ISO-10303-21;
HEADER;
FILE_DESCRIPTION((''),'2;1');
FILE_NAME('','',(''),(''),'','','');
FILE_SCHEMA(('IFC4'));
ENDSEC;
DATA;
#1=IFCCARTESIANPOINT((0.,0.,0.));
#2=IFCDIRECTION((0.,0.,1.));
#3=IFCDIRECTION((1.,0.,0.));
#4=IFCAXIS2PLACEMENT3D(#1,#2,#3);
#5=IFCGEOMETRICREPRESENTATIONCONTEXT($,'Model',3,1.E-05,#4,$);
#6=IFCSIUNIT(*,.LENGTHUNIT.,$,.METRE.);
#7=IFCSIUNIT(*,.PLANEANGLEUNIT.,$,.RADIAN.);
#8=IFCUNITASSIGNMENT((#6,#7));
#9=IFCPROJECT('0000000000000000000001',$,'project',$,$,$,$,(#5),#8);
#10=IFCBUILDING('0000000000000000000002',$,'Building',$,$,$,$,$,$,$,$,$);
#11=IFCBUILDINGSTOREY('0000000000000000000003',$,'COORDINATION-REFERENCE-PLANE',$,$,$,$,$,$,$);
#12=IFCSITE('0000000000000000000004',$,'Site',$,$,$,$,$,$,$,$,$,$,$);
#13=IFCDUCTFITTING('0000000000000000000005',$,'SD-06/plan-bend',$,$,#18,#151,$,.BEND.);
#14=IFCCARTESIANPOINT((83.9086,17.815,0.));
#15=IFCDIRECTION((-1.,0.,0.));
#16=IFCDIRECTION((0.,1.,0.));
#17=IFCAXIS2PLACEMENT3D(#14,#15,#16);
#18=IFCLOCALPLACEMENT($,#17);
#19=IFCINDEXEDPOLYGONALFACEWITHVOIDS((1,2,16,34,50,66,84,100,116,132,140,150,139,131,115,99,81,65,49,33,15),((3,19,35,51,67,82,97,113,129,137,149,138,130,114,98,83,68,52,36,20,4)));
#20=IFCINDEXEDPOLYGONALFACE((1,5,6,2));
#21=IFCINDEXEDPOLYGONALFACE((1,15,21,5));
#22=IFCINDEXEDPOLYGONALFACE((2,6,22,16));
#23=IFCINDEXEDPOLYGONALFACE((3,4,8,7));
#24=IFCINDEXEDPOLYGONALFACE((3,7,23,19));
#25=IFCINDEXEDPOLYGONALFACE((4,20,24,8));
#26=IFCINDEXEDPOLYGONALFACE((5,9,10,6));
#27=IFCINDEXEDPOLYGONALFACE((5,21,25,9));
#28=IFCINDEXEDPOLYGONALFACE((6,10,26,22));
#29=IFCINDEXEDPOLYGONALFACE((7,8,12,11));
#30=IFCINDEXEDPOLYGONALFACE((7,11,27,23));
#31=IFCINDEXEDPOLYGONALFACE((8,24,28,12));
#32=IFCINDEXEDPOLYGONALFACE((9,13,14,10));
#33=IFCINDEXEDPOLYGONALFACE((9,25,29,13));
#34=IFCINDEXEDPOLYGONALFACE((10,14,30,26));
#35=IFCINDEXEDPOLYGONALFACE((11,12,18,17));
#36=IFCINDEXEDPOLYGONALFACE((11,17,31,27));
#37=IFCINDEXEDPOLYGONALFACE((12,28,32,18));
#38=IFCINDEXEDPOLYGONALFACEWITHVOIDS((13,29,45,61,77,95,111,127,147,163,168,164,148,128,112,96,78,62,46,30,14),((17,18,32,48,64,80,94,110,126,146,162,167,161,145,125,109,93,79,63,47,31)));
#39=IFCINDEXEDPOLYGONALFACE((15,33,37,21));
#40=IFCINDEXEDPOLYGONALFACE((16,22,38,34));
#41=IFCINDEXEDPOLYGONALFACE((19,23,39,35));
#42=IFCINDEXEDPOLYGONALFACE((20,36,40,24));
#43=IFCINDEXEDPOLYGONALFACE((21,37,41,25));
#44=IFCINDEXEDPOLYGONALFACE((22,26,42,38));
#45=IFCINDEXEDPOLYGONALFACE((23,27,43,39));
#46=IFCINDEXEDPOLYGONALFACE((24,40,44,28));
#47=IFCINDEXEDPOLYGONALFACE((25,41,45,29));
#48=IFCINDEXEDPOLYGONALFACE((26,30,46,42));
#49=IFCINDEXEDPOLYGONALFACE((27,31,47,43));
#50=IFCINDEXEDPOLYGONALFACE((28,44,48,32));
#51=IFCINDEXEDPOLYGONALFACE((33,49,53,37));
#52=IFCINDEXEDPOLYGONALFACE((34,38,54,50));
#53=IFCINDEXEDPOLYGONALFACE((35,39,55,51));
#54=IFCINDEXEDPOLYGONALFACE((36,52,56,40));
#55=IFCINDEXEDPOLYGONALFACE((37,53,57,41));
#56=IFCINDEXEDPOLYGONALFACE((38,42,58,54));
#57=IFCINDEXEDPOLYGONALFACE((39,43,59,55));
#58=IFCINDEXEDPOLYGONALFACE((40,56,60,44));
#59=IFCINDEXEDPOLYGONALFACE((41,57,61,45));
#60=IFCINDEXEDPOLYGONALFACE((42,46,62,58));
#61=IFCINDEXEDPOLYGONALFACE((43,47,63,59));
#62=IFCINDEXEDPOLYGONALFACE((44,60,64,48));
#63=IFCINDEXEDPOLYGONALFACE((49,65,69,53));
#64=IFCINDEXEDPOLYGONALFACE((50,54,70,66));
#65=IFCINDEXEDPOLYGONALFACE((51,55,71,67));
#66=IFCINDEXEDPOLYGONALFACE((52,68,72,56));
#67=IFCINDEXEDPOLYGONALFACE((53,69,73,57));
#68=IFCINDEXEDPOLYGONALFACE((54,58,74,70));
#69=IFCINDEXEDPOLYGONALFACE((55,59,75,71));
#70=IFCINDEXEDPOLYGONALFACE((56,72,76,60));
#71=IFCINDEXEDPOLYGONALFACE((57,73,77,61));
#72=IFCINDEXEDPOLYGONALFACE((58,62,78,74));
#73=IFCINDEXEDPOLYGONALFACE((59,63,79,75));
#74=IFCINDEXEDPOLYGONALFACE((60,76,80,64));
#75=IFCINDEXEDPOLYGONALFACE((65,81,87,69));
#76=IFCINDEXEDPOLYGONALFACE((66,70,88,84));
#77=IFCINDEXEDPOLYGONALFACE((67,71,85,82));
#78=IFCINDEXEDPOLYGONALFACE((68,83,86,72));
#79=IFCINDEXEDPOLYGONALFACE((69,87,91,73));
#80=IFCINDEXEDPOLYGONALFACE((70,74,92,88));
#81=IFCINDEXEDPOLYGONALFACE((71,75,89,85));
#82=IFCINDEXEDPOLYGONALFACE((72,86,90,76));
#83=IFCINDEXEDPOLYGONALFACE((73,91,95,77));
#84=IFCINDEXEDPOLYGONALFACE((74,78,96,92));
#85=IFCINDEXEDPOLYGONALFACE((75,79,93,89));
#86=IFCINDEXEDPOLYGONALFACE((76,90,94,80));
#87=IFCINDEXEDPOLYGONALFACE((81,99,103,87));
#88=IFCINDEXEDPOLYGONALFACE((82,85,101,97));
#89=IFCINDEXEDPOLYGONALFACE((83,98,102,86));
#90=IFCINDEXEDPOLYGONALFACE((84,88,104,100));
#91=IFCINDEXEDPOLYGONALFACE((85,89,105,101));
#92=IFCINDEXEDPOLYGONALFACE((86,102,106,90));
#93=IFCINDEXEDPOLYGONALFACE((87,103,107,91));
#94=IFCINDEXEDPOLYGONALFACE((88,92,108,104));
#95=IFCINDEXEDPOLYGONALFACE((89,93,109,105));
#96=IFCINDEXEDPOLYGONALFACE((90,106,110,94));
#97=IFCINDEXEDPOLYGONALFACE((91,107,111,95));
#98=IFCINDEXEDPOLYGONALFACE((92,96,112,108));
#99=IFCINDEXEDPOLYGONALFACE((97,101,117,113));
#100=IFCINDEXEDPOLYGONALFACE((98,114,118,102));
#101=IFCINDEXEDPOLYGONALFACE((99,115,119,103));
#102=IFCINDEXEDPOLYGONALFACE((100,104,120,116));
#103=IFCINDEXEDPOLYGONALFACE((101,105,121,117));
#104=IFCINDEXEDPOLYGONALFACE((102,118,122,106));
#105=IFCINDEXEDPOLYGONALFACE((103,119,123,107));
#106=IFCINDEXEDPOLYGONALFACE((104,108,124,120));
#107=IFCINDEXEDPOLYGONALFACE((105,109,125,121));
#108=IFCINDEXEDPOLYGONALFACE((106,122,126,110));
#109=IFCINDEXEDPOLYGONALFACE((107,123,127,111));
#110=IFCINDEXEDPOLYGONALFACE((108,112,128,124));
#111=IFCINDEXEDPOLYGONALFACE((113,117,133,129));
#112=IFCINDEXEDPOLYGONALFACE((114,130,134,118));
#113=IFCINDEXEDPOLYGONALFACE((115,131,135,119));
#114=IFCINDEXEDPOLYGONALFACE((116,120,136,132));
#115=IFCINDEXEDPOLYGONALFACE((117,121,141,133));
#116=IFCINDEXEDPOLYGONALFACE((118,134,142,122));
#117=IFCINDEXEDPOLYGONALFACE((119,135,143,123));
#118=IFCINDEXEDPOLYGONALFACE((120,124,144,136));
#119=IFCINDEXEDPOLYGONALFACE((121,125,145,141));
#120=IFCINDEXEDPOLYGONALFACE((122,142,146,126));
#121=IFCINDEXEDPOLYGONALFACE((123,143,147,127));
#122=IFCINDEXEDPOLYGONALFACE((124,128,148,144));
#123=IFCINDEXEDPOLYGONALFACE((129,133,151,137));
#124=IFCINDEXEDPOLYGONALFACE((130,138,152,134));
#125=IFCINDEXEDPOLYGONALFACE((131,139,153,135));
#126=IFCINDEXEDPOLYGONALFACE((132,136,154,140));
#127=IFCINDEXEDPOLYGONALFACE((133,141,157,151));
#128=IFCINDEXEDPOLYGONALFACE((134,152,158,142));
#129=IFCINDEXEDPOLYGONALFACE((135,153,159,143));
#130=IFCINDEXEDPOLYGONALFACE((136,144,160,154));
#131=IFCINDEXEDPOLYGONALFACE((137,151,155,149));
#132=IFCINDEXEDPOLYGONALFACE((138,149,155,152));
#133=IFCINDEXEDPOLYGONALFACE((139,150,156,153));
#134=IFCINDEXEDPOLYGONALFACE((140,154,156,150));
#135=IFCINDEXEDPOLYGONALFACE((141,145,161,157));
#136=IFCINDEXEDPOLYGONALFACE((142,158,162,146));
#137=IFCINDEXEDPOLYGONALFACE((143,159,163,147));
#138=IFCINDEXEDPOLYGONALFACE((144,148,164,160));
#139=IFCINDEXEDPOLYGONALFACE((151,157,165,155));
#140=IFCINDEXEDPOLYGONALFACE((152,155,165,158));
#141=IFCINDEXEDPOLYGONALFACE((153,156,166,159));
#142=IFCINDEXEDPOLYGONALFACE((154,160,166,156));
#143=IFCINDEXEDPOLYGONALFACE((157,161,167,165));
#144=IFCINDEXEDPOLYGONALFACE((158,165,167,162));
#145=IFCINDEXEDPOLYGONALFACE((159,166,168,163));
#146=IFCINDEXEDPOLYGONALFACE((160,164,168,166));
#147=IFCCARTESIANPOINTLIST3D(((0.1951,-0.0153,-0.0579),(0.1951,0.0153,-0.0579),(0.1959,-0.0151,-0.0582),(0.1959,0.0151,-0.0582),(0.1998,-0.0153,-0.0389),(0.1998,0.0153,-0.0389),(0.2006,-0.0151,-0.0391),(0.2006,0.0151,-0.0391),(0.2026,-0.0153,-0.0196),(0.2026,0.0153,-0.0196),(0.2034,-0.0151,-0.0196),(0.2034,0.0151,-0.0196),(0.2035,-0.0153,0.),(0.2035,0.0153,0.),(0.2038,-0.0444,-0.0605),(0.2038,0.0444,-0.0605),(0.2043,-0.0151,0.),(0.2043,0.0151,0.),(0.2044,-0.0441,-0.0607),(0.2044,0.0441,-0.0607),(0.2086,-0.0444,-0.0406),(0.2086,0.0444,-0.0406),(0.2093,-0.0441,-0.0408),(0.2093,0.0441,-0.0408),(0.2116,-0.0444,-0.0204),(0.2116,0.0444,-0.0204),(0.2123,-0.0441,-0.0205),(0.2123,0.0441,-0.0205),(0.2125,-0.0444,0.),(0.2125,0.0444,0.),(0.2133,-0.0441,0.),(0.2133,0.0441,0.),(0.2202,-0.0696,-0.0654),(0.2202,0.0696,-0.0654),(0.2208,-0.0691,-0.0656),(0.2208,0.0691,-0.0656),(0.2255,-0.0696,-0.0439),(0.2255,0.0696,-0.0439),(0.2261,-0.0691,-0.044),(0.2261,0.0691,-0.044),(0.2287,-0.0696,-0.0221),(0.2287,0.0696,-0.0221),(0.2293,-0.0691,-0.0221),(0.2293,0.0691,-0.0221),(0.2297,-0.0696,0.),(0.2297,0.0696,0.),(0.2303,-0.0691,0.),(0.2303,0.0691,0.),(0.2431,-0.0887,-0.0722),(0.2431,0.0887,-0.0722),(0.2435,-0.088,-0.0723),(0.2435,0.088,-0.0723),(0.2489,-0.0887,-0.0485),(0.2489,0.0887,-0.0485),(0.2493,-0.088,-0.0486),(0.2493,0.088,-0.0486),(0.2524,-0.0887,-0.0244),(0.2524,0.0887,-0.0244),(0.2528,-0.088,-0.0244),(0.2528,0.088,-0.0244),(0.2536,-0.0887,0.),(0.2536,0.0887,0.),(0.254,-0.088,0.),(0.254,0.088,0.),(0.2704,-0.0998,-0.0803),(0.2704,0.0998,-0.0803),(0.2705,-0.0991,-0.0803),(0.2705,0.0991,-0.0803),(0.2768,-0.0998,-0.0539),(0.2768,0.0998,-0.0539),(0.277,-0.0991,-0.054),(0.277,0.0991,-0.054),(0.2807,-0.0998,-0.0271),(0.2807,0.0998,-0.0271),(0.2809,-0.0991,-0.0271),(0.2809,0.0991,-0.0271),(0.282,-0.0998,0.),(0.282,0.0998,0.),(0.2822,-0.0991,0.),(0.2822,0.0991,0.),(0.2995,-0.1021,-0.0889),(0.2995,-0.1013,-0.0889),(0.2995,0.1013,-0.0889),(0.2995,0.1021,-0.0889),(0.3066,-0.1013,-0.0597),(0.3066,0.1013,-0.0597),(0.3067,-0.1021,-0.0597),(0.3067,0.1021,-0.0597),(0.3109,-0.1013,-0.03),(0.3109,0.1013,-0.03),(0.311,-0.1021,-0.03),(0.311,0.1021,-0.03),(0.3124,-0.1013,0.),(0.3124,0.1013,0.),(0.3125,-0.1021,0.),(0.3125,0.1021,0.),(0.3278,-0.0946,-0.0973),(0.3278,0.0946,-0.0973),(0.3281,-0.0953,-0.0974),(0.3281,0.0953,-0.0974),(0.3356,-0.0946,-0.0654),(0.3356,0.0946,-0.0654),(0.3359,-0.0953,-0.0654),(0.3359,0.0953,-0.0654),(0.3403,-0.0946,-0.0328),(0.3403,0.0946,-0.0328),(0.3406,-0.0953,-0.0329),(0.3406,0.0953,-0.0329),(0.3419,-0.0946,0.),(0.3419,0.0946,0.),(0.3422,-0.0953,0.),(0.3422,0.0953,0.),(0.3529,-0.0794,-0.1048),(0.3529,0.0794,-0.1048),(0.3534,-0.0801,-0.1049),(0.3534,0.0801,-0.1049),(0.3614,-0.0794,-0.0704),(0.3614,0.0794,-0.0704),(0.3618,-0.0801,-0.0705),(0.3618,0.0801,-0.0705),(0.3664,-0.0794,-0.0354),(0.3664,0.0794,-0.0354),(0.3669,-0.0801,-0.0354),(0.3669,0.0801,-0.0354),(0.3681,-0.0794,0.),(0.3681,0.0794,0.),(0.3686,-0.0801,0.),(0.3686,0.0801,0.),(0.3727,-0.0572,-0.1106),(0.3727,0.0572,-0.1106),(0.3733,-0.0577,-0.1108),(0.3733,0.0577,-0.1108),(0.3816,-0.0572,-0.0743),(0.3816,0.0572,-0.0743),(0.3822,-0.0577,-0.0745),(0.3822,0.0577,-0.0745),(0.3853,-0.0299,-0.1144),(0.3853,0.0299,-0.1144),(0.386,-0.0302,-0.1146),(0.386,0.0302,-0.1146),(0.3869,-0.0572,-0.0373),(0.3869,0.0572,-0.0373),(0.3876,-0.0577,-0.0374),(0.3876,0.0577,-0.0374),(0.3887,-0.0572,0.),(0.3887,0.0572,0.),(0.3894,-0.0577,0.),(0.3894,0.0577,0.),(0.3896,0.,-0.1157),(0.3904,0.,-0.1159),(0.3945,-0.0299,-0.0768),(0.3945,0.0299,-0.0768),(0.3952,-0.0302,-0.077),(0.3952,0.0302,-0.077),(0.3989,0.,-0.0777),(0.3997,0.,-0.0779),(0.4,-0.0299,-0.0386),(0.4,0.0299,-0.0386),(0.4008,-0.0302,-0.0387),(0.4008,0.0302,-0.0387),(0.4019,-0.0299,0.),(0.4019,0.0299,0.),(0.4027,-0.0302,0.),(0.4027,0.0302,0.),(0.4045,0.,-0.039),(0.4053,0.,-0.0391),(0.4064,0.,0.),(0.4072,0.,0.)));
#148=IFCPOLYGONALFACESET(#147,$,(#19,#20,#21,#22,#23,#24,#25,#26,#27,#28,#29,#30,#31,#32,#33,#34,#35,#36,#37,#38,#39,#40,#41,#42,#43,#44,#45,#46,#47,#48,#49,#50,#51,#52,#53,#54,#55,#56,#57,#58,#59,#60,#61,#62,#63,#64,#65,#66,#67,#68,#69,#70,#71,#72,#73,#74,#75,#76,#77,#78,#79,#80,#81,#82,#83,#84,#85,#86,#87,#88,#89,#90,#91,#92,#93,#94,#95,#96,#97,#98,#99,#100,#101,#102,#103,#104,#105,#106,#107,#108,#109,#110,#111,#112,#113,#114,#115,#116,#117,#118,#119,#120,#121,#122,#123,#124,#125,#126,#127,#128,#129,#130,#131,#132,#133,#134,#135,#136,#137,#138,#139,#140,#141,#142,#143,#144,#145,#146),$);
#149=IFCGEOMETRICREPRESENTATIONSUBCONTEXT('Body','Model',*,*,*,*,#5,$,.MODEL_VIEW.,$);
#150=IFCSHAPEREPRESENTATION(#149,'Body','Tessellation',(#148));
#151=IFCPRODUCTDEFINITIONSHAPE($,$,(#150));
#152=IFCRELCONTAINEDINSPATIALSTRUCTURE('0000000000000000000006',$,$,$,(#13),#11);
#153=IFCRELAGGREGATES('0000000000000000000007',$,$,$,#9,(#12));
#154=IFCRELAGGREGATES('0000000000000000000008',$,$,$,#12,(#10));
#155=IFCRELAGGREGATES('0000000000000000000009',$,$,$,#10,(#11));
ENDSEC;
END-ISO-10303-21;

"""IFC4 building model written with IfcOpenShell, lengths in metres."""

from ifc_helpers import new_model, entity, si_unit, frame, origin_with_axes, place, context, subcontext, project, spatial, element, save


model = new_model("IFC4")

# Units and contexts
model_context = context("Model", 3, precision=1e-05, world=origin_with_axes())
body_context_1 = subcontext(model_context, "Body", "Model", "MODEL_VIEW")
ifc_project = project(units=[si_unit("LENGTHUNIT", "METRE"), si_unit("PLANEANGLEUNIT", "RADIAN")], contexts=[model_context])

# Site, building, storey
site = spatial("IfcSite", under=ifc_project, Name="Site")
building = spatial("IfcBuilding", under=site, Name="Building")
storey = spatial("IfcBuildingStorey", under=building, Name="COORDINATION-REFERENCE-PLANE")

# Duct fitting
duct_fitting_1_placement = place(None, frame((83.9086, 17.815, 0.0), z_axis=(-1.0, 0.0, 0.0), x_axis=(0.0, 1.0, 0.0)))
element("IfcDuctFitting", 1, at=duct_fitting_1_placement, inside=storey, Name="SD-06/plan-bend", PredefinedType="BEND", context=body_context_1, shape_type="SweptSolid", body=[
    entity("IfcRevolvedAreaSolid", entity("IfcCircleHollowProfileDef", "AREA", None, entity("IfcAxis2Placement2D", entity("IfcCartesianPoint", [0.3048, 0.0])), 0.1024, 0.0008), entity("IfcAxis2Placement3D", entity("IfcCartesianPoint", [0.0, 0.0, 0.0]), entity("IfcDirection", [0.0, 0.0, 1.0]), entity("IfcDirection", [1.0, 0.0, 0.0])), entity("IfcAxis1Placement", entity("IfcCartesianPoint", [0.0, 0.0, 0.0]), entity("IfcDirection", [0.0, 1.0, 0.0])), 0.288593),
])

save(model, "model.ifc")
